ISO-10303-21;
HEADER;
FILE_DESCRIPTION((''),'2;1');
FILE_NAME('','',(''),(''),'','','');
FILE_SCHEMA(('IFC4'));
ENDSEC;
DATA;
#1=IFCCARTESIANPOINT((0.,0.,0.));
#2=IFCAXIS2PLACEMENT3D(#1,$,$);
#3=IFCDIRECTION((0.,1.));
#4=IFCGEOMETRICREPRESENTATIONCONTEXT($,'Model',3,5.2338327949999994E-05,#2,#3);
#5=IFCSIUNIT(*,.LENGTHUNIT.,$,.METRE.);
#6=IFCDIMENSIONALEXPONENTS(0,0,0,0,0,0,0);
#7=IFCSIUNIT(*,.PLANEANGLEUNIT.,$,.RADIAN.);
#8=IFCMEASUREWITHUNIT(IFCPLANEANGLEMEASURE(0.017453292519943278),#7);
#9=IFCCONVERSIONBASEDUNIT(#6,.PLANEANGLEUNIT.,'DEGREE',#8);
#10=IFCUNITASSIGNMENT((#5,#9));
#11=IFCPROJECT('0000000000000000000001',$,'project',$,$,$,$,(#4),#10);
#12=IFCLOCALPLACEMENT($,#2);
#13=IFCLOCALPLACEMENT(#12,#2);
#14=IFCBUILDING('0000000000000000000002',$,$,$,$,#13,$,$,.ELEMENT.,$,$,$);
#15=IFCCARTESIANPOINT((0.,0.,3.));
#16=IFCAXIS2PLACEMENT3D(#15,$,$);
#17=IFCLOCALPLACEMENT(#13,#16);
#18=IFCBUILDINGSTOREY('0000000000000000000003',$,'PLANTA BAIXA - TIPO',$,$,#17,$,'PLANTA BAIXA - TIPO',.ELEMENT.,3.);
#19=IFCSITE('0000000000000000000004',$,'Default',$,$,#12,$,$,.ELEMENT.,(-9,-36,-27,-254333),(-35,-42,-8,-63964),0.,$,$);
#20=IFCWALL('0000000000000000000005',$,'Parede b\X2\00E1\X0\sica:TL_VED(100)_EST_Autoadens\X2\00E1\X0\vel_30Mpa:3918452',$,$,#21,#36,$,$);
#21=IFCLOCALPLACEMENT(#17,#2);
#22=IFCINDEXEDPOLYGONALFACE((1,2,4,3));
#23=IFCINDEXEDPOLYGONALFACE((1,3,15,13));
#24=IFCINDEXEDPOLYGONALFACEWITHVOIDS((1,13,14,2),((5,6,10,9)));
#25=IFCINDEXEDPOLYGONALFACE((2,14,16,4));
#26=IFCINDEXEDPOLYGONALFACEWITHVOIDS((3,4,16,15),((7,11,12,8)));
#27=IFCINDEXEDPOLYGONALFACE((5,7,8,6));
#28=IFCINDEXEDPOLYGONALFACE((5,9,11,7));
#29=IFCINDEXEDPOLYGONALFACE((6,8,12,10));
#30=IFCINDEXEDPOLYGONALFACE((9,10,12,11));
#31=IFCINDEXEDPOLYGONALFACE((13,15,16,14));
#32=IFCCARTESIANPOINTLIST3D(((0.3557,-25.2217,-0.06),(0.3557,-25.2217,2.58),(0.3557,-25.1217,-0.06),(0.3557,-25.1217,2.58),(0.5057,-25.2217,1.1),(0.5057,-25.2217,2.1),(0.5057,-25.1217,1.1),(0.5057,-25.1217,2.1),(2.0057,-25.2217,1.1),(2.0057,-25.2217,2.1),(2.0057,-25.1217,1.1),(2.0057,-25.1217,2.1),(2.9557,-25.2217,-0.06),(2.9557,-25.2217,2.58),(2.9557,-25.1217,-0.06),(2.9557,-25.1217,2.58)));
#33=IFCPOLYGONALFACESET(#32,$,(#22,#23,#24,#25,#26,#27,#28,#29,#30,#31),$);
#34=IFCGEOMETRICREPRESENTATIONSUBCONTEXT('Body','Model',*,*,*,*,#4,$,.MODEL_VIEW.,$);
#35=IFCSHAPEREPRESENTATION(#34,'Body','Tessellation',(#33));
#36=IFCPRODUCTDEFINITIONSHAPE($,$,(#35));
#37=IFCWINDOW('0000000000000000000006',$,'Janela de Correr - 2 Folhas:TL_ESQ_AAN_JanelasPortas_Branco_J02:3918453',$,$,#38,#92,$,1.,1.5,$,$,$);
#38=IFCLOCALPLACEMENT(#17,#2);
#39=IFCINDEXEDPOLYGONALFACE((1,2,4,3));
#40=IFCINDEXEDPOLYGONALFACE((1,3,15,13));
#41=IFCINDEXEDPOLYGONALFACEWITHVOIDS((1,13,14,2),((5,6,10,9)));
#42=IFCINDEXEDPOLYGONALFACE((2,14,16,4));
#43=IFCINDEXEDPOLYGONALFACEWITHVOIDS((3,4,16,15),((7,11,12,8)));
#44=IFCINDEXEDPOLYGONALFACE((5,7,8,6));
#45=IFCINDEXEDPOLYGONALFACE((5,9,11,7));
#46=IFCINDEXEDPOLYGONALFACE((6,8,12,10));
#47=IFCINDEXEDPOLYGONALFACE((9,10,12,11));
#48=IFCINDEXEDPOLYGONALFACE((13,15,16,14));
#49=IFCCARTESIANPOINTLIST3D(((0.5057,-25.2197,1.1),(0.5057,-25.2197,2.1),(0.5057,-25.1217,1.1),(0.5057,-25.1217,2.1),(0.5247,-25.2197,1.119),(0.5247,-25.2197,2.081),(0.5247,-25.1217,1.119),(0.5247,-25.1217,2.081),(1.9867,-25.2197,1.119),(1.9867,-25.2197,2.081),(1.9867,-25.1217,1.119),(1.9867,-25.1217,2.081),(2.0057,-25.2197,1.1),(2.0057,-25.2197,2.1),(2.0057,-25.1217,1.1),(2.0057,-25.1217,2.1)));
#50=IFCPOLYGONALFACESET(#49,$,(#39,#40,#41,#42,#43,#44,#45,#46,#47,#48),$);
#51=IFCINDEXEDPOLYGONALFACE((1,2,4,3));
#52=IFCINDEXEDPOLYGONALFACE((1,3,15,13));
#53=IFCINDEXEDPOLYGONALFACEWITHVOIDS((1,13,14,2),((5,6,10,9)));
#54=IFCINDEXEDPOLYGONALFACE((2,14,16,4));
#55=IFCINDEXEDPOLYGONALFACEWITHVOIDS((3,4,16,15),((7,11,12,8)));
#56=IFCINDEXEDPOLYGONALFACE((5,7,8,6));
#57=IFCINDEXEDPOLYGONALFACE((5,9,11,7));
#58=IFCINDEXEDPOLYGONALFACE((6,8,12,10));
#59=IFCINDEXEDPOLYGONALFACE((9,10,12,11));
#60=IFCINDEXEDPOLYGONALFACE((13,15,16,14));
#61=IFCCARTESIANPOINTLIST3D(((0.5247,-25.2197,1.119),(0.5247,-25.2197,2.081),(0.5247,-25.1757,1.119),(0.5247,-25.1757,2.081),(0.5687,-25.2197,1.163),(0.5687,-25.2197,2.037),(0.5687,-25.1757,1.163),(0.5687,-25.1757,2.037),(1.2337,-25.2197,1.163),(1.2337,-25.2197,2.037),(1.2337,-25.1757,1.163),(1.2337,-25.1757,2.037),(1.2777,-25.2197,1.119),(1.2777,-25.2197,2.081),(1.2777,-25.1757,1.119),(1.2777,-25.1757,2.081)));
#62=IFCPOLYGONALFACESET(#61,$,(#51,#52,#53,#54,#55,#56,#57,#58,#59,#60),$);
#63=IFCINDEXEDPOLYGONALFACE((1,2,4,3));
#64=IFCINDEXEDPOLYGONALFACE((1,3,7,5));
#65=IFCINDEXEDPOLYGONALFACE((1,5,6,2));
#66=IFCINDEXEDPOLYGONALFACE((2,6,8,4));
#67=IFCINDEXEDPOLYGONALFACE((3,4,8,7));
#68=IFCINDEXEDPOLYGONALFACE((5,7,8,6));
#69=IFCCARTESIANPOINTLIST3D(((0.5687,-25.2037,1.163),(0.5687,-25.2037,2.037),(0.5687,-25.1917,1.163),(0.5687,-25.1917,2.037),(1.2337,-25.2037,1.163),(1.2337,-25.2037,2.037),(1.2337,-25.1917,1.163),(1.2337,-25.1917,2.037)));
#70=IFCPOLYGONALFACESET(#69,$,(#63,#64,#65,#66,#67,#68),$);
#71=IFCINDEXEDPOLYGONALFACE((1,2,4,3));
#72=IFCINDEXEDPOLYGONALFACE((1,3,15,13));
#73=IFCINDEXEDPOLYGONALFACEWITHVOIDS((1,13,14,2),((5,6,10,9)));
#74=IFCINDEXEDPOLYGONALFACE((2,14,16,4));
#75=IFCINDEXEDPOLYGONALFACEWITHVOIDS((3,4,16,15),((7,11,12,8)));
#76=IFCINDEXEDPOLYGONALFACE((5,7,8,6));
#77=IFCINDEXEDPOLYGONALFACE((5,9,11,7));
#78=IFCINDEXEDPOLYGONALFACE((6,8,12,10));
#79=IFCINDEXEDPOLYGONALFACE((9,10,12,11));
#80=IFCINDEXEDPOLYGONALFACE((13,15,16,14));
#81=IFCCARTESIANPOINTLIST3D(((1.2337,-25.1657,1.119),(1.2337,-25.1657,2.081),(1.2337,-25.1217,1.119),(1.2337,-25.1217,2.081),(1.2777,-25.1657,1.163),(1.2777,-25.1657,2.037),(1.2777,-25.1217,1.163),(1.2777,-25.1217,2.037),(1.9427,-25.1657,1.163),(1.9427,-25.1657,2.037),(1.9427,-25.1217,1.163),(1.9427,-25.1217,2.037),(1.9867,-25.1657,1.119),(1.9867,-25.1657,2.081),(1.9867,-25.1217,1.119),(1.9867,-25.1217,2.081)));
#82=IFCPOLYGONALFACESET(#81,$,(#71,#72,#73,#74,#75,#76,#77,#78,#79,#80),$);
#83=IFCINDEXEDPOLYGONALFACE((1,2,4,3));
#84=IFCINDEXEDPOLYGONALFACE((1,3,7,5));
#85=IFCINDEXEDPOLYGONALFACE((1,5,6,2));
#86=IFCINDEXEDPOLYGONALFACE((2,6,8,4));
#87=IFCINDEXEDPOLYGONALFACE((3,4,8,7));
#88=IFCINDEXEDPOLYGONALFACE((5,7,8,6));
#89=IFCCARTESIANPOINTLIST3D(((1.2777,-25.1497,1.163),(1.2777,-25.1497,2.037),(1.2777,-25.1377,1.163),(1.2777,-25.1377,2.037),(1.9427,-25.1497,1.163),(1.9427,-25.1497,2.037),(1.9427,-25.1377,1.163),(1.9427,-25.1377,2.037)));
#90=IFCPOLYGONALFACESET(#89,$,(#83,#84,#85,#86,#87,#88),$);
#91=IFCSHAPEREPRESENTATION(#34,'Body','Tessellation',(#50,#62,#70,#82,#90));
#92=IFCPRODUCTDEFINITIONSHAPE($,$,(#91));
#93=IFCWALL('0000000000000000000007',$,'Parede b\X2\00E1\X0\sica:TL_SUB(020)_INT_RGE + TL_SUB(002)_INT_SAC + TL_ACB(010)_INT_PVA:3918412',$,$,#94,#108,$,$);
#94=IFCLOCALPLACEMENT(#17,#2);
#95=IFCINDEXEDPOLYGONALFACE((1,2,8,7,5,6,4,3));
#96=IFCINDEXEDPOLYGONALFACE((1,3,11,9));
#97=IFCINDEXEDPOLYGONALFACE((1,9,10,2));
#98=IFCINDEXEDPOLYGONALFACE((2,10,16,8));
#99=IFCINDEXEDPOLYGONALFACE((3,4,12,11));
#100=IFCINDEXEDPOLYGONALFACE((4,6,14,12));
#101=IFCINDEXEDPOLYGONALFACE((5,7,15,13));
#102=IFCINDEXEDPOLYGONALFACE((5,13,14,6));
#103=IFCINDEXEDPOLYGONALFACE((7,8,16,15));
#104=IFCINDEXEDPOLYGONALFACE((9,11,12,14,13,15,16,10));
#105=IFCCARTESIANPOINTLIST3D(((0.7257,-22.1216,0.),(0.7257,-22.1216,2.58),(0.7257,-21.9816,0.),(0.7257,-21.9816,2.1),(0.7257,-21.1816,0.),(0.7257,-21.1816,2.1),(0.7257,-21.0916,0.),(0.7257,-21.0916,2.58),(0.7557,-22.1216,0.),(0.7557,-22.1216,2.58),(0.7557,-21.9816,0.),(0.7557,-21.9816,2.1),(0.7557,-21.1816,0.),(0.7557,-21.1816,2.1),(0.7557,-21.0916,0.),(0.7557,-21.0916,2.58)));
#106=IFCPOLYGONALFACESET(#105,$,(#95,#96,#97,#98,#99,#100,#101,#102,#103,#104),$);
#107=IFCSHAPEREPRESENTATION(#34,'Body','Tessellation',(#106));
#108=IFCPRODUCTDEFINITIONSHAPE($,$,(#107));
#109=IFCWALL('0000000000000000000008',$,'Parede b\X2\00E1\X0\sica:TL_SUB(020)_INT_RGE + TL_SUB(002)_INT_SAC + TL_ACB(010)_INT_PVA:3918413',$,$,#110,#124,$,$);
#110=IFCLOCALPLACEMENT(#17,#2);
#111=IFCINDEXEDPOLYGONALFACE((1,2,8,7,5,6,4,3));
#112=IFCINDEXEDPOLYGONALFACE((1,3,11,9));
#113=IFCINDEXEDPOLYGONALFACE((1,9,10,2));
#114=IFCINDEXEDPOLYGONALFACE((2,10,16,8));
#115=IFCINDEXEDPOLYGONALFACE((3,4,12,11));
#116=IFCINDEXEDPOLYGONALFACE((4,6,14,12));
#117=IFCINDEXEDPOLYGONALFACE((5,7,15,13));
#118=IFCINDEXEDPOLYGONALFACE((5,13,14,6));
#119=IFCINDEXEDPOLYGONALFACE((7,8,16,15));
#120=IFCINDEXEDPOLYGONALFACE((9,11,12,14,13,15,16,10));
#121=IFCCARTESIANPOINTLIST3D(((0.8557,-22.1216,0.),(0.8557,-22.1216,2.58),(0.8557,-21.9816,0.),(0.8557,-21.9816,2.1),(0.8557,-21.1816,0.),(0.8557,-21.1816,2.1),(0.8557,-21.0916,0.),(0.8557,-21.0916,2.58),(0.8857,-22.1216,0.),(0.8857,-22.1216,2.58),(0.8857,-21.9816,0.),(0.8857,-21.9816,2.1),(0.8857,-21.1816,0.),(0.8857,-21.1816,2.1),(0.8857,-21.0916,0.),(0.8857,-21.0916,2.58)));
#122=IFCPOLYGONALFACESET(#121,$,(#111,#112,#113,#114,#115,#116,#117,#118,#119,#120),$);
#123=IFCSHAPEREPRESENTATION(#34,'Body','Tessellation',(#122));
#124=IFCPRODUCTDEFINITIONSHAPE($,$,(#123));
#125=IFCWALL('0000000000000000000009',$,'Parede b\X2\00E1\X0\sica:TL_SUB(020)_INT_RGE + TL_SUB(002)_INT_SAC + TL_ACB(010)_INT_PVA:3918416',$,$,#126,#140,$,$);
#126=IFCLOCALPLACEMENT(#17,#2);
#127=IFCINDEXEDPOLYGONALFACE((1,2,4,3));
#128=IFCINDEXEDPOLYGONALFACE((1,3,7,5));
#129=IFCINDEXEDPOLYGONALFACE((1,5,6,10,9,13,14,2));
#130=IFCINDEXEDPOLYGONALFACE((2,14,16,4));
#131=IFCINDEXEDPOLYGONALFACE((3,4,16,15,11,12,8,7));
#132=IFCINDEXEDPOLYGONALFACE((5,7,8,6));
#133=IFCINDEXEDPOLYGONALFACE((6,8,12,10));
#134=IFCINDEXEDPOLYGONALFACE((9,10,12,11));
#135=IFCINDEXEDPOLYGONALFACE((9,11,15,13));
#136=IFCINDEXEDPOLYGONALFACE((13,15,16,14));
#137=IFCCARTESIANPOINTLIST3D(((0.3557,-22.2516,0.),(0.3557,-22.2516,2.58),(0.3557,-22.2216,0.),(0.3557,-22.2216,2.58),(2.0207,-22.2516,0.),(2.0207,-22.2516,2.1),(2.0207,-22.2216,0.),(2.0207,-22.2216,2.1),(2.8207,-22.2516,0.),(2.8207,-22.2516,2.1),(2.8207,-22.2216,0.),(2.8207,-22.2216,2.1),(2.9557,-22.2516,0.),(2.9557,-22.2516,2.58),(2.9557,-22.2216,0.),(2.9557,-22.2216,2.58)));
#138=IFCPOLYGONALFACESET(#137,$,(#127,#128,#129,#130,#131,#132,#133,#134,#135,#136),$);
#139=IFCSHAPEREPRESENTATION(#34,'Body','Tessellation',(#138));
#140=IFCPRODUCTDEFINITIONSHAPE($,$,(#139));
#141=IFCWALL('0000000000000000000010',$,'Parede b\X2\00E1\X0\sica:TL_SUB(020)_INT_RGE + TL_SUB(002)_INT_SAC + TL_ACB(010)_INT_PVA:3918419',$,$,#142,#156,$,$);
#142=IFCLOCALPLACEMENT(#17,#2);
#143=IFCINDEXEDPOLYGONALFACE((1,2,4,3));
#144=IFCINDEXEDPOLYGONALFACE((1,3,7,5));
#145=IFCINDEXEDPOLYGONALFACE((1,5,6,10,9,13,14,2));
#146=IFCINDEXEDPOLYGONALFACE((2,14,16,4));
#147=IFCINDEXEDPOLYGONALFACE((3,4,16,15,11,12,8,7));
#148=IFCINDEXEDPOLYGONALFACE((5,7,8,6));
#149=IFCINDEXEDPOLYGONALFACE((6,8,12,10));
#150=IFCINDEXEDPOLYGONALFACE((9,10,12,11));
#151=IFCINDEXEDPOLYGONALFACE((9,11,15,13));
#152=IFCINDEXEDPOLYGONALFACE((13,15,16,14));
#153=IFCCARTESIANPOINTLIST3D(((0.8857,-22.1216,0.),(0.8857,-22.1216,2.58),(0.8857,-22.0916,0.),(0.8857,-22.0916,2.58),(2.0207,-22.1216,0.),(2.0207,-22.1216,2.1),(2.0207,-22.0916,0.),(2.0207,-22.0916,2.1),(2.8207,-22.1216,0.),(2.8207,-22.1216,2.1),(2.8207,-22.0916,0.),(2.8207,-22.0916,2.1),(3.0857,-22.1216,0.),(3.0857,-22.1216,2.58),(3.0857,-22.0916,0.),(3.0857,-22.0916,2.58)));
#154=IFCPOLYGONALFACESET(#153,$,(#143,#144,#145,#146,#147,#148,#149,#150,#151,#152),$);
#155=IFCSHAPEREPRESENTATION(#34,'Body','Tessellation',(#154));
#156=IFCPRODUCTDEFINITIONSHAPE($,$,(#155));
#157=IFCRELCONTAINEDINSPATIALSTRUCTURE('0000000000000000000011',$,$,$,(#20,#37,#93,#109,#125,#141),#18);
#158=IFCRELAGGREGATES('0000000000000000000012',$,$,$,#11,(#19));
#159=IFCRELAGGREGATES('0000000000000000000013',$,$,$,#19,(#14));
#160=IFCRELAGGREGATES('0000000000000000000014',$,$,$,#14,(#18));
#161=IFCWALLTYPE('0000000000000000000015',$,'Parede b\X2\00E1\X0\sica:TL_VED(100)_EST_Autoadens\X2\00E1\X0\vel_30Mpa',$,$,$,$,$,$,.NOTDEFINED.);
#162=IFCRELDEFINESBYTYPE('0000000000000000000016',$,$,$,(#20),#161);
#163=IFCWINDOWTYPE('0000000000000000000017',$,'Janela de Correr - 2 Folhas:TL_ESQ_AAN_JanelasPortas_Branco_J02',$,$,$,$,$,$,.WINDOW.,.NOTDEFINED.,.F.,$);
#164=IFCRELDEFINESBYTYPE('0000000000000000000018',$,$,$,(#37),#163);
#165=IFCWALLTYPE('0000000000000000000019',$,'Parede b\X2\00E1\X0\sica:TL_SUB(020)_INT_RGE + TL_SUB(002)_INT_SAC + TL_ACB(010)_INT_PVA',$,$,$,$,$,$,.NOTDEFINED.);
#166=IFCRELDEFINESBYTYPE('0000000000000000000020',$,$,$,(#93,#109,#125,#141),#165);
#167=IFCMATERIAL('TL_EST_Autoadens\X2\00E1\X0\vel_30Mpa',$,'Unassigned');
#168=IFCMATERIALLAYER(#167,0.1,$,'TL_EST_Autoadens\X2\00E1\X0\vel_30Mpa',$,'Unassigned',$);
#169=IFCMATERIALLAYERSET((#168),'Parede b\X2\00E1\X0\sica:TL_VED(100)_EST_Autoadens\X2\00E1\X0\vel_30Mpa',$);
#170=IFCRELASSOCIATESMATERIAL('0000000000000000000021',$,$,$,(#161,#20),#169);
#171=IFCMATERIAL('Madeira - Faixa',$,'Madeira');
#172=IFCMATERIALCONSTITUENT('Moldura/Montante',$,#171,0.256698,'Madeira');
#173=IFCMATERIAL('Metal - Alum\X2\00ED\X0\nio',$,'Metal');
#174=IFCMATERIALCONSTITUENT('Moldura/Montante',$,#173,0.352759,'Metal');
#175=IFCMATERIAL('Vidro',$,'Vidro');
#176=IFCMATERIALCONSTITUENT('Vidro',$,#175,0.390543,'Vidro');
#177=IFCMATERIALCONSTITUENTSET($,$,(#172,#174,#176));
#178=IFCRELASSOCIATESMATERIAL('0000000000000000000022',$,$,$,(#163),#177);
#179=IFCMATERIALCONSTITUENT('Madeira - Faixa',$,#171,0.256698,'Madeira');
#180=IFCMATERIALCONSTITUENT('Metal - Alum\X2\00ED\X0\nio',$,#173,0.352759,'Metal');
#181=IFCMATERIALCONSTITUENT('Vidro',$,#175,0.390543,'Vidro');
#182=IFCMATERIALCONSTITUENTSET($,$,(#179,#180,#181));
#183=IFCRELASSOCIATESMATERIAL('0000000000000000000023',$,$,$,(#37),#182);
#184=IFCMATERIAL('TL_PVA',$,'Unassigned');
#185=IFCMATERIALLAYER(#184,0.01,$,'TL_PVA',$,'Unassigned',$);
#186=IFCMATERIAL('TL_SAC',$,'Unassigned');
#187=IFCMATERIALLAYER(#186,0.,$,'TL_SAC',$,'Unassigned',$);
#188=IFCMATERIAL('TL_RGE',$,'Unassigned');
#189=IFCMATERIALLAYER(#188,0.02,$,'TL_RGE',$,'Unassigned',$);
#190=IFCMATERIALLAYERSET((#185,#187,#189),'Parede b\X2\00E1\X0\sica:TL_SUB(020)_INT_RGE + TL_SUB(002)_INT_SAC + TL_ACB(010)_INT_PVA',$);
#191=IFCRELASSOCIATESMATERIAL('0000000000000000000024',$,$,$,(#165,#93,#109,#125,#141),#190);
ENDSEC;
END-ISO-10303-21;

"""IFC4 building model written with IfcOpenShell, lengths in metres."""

from ifc_helpers import new_model, entity, si_unit, converted_unit, direction, frame, frame_2d, origin, origin_2d_with_axis, place, context, subcontext, project, spatial, polyline, rectangle, outline, extrude, source, transform, mapped, material, layer, layer_set, layer_usage, constituent, constituent_set, type_object, type_shapes, element, fill, save


model = new_model("IFC4")

# Units and contexts
model_context = context("Model", 3, precision=5.2338327949999994e-05, world=origin(), true_north=direction((0.0, 1.0)))
body_context = subcontext(model_context, "Body", "Model", "MODEL_VIEW")
ifc_project = project(units=[si_unit("LENGTHUNIT", "METRE"), converted_unit("PLANEANGLEUNIT", "DEGREE", entity("IfcPlaneAngleMeasure", 0.017453292519943278), si_unit("PLANEANGLEUNIT", "RADIAN"), dimensions=[0, 0, 0, 0, 0, 0, 0])], contexts=[model_context])

# Site, building, storey
site_placement = place(None, frame((0.0, 0.0, 0.0)))
site = spatial("IfcSite", under=ifc_project, at=site_placement, Name="Default", CompositionType="ELEMENT", RefLatitude=(-9, -36, -27, -254333), RefLongitude=(-35, -42, -8, -63964), RefElevation=0.0)
building_placement = place(site_placement, origin())
building = spatial("IfcBuilding", under=site, at=building_placement, CompositionType="ELEMENT")
storey_placement = place(building_placement, frame((0.0, 0.0, 3.0)))
storey = spatial("IfcBuildingStorey", under=building, at=storey_placement, Name="PLANTA BAIXA - TIPO", LongName="PLANTA BAIXA - TIPO", CompositionType="ELEMENT", Elevation=3.0)

# Shared definitions
ifc_material_1 = material(Name="TL_EST_Autoadensável_30Mpa", Category="Unassigned")
ifc_layer_1 = layer(ifc_material_1, 0.1, Name="TL_EST_Autoadensável_30Mpa", Category="Unassigned")
ifc_layer_set_1 = layer_set([ifc_layer_1], Name="Parede básica:TL_VED(100)_EST_Autoadensável_30Mpa")
wall_type_1 = type_object("IfcWallType", Name="Parede básica:TL_VED(100)_EST_Autoadensável_30Mpa", PredefinedType="NOTDEFINED", material=ifc_layer_set_1)

# Shared definitions
ifc_material_2 = material(Name="Vidro", Category="Vidro")

# Wall, opening, window
ifc_layer_usage_1 = layer_usage(ifc_layer_set_1, "AXIS2", "POSITIVE", -0.05)
wall_1_placement = place(storey_placement, frame((0.3557, -25.1717, -0.06)))
wall_1 = element("IfcWall", 1, at=wall_1_placement, inside=storey, type_object=wall_type_1, material=ifc_layer_usage_1, Name="Parede básica:TL_VED(100)_EST_Autoadensável_30Mpa:3918452", context=body_context, shape_type="SweptSolid", body=[
    extrude(rectangle(XDim=2.6, YDim=0.1, at=frame_2d((1.3, 0.0), x_axis=(-1.0, 0.0))), origin(), (0.0, 0.0, 1.0), 2.64),
])
opening_1_placement = place(wall_1_placement, frame((1.65, 0.05, 1.16)))
opening_1 = element("IfcOpeningElement", 2, at=opening_1_placement, cuts=wall_1, PredefinedType="OPENING", context=body_context, shape_type="SweptSolid", body=[
    extrude(rectangle(XDim=1.0, YDim=1.5, at=frame_2d((0.5, 0.75), x_axis=(-1.0, 0.0))), frame((0.0, 0.0, 0.0), z_axis=(0.0, -1.0, 0.0), x_axis=(0.0, 0.0, 1.0)), (0.0, 0.0, 1.0), 0.1),
])
ifc_material_3 = material(Name="Madeira - Faixa", Category="Madeira")
ifc_constituent_1 = constituent(ifc_material_3, Name="Madeira - Faixa", Category="Madeira", fraction=0.256698)
ifc_material_4 = material(Name="Metal - Alumínio", Category="Metal")
ifc_constituent_2 = constituent(ifc_material_4, Name="Metal - Alumínio", Category="Metal", fraction=0.352759)
ifc_constituent_3 = constituent(ifc_material_2, Name="Vidro", Category="Vidro", fraction=0.390543)
ifc_constituent_set_1 = constituent_set(constituents=[ifc_constituent_1, ifc_constituent_2, ifc_constituent_3])
ifc_constituent_4 = constituent(ifc_material_3, Name="Moldura/Montante", Category="Madeira", fraction=0.256698)
ifc_constituent_5 = constituent(ifc_material_4, Name="Moldura/Montante", Category="Metal", fraction=0.352759)
ifc_constituent_6 = constituent(ifc_material_2, Name="Vidro", Category="Vidro", fraction=0.390543)
ifc_constituent_set_2 = constituent_set(constituents=[ifc_constituent_4, ifc_constituent_5, ifc_constituent_6])
window_type = type_object("IfcWindowType", Name="Janela de Correr - 2 Folhas:TL_ESQ_AAN_JanelasPortas_Branco_J02", ParameterTakesPrecedence=False, PartitioningType="NOTDEFINED", PredefinedType="WINDOW", material=ifc_constituent_set_2)
shared_shape_1 = source(origin(), body_context, "Body", "SweptSolid", [
    extrude(outline(polyline([(-0.75, -0.5), (0.75, -0.5), (0.75, 0.5), (-0.75, 0.5), (-0.75, -0.5)]), holes=[polyline([(-0.731, -0.481), (-0.731, 0.481), (0.731, 0.481), (0.731, -0.481), (-0.731, -0.481)])]), frame((0.75, 0.0, 0.5), z_axis=(0.0, 1.0, 0.0), x_axis=(1.0, 0.0, 0.0)), (0.0, 0.0, 1.0), 0.098),
    extrude(outline(polyline([(-0.3765, -0.481), (0.3765, -0.481), (0.3765, 0.481), (-0.3765, 0.481), (-0.3765, -0.481)]), holes=[polyline([(-0.3325, -0.437), (-0.3325, 0.437), (0.3325, 0.437), (0.3325, -0.437), (-0.3325, -0.437)])]), frame((1.1045, 0.054, 0.5), z_axis=(0.0, 1.0, 0.0), x_axis=(1.0, 0.0, 0.0)), (0.0, 0.0, 1.0), 0.044),
    extrude(rectangle(XDim=0.012, YDim=0.665, at=origin_2d_with_axis()), frame((1.1045, 0.076, 0.063), z_axis=(0.0, 0.0, 1.0), x_axis=(0.0, -1.0, 0.0)), (0.0, 0.0, 1.0), 0.874),
    extrude(outline(polyline([(-0.481, -0.3765), (0.481, -0.3765), (0.481, 0.3765), (-0.481, 0.3765), (-0.481, -0.3765)]), holes=[polyline([(-0.437, -0.3325), (-0.437, 0.3325), (0.437, 0.3325), (0.437, -0.3325), (-0.437, -0.3325)])]), frame((0.3955, 0.0, 0.5), z_axis=(0.0, 1.0, 0.0), x_axis=(0.0, 0.0, -1.0)), (0.0, 0.0, 1.0), 0.044),
    extrude(rectangle(XDim=0.012, YDim=0.665, at=origin_2d_with_axis()), frame((0.3955, 0.022, 0.063), z_axis=(0.0, 0.0, 1.0), x_axis=(0.0, -1.0, 0.0)), (0.0, 0.0, 1.0), 0.874),
])
type_shapes(window_type, [shared_shape_1])
window_placement = place(opening_1_placement, frame((0.0, 0.0, 0.0), z_axis=(0.0, 0.0, 1.0), x_axis=(-1.0, 0.0, 0.0)))
window = element("IfcWindow", 3, at=window_placement, inside=storey, type_object=window_type, material=ifc_constituent_set_1, Name="Janela de Correr - 2 Folhas:TL_ESQ_AAN_JanelasPortas_Branco_J02:3918453", OverallHeight=1.0, OverallWidth=1.5, context=body_context, shape_type="MappedRepresentation", body=[
    mapped(shared_shape_1, transform((0.0, 0.0, 0.0), scale=1.0)),
])
fill(opening_1, window)

# Walls, openings
ifc_material_5 = material(Name="TL_PVA", Category="Unassigned")
ifc_layer_2 = layer(ifc_material_5, 0.01, Name="TL_PVA", Category="Unassigned")
ifc_material_6 = material(Name="TL_SAC", Category="Unassigned")
ifc_layer_3 = layer(ifc_material_6, 0.0, Name="TL_SAC", Category="Unassigned")
ifc_material_7 = material(Name="TL_RGE", Category="Unassigned")
ifc_layer_4 = layer(ifc_material_7, 0.02, Name="TL_RGE", Category="Unassigned")
ifc_layer_set_2 = layer_set([ifc_layer_2, ifc_layer_3, ifc_layer_4], Name="Parede básica:TL_SUB(020)_INT_RGE + TL_SUB(002)_INT_SAC + TL_ACB(010)_INT_PVA")
ifc_layer_usage_2 = layer_usage(ifc_layer_set_2, "AXIS2", "NEGATIVE", 0.015)
wall_type_2 = type_object("IfcWallType", Name="Parede básica:TL_SUB(020)_INT_RGE + TL_SUB(002)_INT_SAC + TL_ACB(010)_INT_PVA", PredefinedType="NOTDEFINED", material=ifc_layer_set_2)
wall_2_placement = place(storey_placement, frame((0.7407, -22.1216, 0.0), z_axis=(0.0, 0.0, 1.0), x_axis=(0.0, 1.0, 0.0)))
wall_2 = element("IfcWall", 4, at=wall_2_placement, inside=storey, type_object=wall_type_2, material=ifc_layer_usage_2, Name="Parede básica:TL_SUB(020)_INT_RGE + TL_SUB(002)_INT_SAC + TL_ACB(010)_INT_PVA:3918412", context=body_context, shape_type="SweptSolid", body=[
    extrude(rectangle(XDim=1.03, YDim=0.03, at=frame_2d((0.515, 0.0), x_axis=(1.0, 0.0))), origin(), (0.0, 0.0, 1.0), 2.58),
])
opening_2_placement = place(wall_2_placement, frame((22.1216, 0.7407, 0.0)))
element("IfcOpeningElement", 5, at=opening_2_placement, cuts=wall_2, PredefinedType="OPENING", context=body_context, shape_type="SweptSolid", body=[
    extrude(rectangle(XDim=2.1, YDim=0.8, at=frame_2d((0.0, 0.0), x_axis=(0.0, 1.0))), frame((-21.5816, -2.3797, 1.05), z_axis=(0.0, 1.0, 0.0), x_axis=(-1.0, 0.0, 0.0)), (0.0, 0.0, 1.0), 3.048),
])
ifc_layer_usage_3 = layer_usage(ifc_layer_set_2, "AXIS2", "NEGATIVE", 0.015)
wall_3_placement = place(storey_placement, frame((0.8707, -21.0916, 0.0), z_axis=(0.0, 0.0, 1.0), x_axis=(0.0, -1.0, 0.0)))
wall_3 = element("IfcWall", 6, at=wall_3_placement, inside=storey, type_object=wall_type_2, material=ifc_layer_usage_3, Name="Parede básica:TL_SUB(020)_INT_RGE + TL_SUB(002)_INT_SAC + TL_ACB(010)_INT_PVA:3918413", context=body_context, shape_type="SweptSolid", body=[
    extrude(rectangle(XDim=1.03, YDim=0.03, at=frame_2d((0.515, 0.0), x_axis=(1.0, 0.0))), origin(), (0.0, 0.0, 1.0), 2.58),
])
opening_3_placement = place(wall_3_placement, frame((-21.0916, -0.8707, 0.0)))
element("IfcOpeningElement", 7, at=opening_3_placement, cuts=wall_3, PredefinedType="OPENING", context=body_context, shape_type="SweptSolid", body=[
    extrude(rectangle(XDim=2.1, YDim=0.8, at=frame_2d((0.0, 0.0), x_axis=(1.0, 0.0))), frame((21.5816, -0.6683, 1.05), z_axis=(0.0, 1.0, 0.0), x_axis=(0.0, 0.0, 1.0)), (0.0, 0.0, 1.0), 3.048),
])
ifc_layer_usage_4 = layer_usage(ifc_layer_set_2, "AXIS2", "NEGATIVE", 0.015)
wall_4_placement = place(storey_placement, frame((2.9557, -22.2366, 0.0), z_axis=(0.0, 0.0, 1.0), x_axis=(-1.0, 0.0, 0.0)))
wall_4 = element("IfcWall", 8, at=wall_4_placement, inside=storey, type_object=wall_type_2, material=ifc_layer_usage_4, Name="Parede básica:TL_SUB(020)_INT_RGE + TL_SUB(002)_INT_SAC + TL_ACB(010)_INT_PVA:3918416", context=body_context, shape_type="SweptSolid", body=[
    extrude(rectangle(XDim=2.6, YDim=0.03, at=frame_2d((1.3, 0.0), x_axis=(-1.0, 0.0))), origin(), (0.0, 0.0, 1.0), 2.58),
])
opening_4_placement = place(wall_4_placement, frame((2.9557, -22.2366, 0.0)))
element("IfcOpeningElement", 9, at=opening_4_placement, cuts=wall_4, PredefinedType="OPENING", context=body_context, shape_type="SweptSolid", body=[
    extrude(rectangle(XDim=2.1, YDim=0.8, at=frame_2d((0.0, 0.0), x_axis=(1.0, 0.0))), frame((-2.4207, 20.5976, 1.05), z_axis=(0.0, 1.0, 0.0), x_axis=(0.0, 0.0, 1.0)), (0.0, 0.0, 1.0), 3.048),
])
ifc_layer_usage_5 = layer_usage(ifc_layer_set_2, "AXIS2", "NEGATIVE", 0.015)
wall_5_placement = place(storey_placement, frame((0.8857, -22.1066, 0.0)))
wall_5 = element("IfcWall", 10, at=wall_5_placement, inside=storey, type_object=wall_type_2, material=ifc_layer_usage_5, Name="Parede básica:TL_SUB(020)_INT_RGE + TL_SUB(002)_INT_SAC + TL_ACB(010)_INT_PVA:3918419", context=body_context, shape_type="SweptSolid", body=[
    extrude(rectangle(XDim=2.2, YDim=0.03, at=frame_2d((1.1, 0.0), x_axis=(1.0, 0.0))), origin(), (0.0, 0.0, 1.0), 2.58),
])
opening_5_placement = place(wall_5_placement, frame((-0.8857, 22.1066, 0.0)))
element("IfcOpeningElement", 11, at=opening_5_placement, cuts=wall_5, PredefinedType="OPENING", context=body_context, shape_type="SweptSolid", body=[
    extrude(rectangle(XDim=2.1, YDim=0.8, at=frame_2d((0.0, 0.0), x_axis=(0.0, 1.0))), frame((2.4207, -23.6456, 1.05), z_axis=(0.0, 1.0, 0.0), x_axis=(-1.0, 0.0, 0.0)), (0.0, 0.0, 1.0), 3.048),
])

save(model, "model.ifc")
